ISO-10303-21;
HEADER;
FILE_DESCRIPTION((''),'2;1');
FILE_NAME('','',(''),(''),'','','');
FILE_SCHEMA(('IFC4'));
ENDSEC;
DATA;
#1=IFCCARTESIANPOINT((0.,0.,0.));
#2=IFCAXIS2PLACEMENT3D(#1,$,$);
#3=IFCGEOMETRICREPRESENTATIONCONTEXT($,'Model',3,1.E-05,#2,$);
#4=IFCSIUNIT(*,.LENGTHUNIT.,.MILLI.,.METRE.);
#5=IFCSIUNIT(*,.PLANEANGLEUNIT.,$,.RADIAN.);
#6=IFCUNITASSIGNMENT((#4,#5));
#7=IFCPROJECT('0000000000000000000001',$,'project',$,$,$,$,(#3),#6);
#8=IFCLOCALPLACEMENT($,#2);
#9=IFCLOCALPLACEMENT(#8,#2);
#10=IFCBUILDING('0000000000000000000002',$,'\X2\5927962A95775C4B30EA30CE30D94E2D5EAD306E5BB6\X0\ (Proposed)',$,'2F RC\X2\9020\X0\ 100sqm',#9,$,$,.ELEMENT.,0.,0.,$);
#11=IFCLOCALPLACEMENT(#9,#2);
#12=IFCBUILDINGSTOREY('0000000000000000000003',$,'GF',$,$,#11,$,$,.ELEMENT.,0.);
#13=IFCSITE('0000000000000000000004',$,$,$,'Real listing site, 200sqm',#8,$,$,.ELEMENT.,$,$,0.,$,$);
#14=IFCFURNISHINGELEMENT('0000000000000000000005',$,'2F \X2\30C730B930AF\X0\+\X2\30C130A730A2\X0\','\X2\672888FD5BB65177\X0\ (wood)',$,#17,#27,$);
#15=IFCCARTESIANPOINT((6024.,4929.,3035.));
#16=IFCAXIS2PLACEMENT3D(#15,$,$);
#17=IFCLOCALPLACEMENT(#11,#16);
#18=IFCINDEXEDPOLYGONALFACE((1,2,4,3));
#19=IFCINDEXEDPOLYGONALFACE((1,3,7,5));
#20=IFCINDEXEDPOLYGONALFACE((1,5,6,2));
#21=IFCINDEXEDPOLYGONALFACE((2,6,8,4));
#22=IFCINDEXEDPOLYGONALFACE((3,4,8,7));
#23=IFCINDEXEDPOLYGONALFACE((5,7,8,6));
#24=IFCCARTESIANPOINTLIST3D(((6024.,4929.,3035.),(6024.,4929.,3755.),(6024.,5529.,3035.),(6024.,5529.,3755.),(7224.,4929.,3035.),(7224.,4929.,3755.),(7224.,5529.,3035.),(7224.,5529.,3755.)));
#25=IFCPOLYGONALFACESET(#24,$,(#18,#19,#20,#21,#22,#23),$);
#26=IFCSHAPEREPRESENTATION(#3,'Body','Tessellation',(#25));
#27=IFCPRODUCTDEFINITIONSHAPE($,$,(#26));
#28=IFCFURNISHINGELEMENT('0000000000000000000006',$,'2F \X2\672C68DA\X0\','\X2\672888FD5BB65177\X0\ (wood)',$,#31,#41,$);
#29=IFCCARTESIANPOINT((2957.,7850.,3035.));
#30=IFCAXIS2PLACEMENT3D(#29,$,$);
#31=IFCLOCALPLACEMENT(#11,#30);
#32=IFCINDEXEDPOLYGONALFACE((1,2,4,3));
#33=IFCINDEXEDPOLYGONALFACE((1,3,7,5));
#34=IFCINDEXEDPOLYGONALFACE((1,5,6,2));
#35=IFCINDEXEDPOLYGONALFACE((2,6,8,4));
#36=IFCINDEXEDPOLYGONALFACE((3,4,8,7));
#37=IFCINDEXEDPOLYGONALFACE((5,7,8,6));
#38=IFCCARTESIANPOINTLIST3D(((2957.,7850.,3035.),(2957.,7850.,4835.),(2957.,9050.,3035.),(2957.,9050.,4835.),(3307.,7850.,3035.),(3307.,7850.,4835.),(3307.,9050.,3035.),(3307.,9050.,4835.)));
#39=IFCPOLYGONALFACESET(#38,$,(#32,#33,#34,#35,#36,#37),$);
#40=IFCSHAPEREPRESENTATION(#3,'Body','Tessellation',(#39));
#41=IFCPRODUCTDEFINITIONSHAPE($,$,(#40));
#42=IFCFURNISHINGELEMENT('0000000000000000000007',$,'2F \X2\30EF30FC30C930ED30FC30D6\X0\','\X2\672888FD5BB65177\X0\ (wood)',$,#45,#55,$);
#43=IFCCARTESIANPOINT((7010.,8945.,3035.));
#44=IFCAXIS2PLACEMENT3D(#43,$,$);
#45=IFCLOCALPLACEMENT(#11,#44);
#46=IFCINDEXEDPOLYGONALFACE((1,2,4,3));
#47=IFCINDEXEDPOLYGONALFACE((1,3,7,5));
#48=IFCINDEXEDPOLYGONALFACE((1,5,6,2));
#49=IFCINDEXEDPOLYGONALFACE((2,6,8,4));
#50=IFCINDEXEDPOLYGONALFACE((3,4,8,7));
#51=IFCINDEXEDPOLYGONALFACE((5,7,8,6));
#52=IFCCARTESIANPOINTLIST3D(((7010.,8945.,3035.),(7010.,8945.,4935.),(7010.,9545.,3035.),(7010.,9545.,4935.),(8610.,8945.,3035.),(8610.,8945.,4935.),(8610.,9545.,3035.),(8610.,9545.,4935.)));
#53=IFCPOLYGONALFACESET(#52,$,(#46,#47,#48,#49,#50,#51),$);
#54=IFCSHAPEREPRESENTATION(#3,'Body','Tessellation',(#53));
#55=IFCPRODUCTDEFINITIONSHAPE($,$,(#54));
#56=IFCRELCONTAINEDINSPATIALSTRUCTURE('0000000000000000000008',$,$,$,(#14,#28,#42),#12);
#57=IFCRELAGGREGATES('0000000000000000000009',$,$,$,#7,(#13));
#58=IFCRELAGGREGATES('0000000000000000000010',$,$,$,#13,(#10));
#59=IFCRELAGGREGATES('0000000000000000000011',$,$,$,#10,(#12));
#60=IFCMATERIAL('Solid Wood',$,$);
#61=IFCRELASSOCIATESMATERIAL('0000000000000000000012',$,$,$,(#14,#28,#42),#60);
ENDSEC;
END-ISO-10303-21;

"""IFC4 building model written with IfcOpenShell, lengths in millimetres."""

from ifc_helpers import new_model, si_unit, frame, frame_2d, origin, place, context, project, spatial, rectangle, extrude, material, element, save


model = new_model("IFC4")

# Units and contexts
model_context = context("Model", 3, precision=1e-05, world=origin())
ifc_project = project(units=[si_unit("LENGTHUNIT", "METRE", prefix="MILLI"), si_unit("PLANEANGLEUNIT", "RADIAN")], contexts=[model_context])

# Site, building, storey
site_placement = place(None, origin())
site = spatial("IfcSite", under=ifc_project, at=site_placement, ObjectType="Real listing site, 200sqm", CompositionType="ELEMENT", RefElevation=0.0)
building_placement = place(site_placement, origin())
building = spatial("IfcBuilding", under=site, at=building_placement, Name="大阪長屋リノベ中庭の家 (Proposed)", ObjectType="2F RC造 100sqm", CompositionType="ELEMENT", ElevationOfRefHeight=0.0, ElevationOfTerrain=0.0)
storey_placement = place(building_placement, origin())
storey = spatial("IfcBuildingStorey", under=building, at=storey_placement, Name="GF", CompositionType="ELEMENT", Elevation=0.0)

# Shared definitions
ifc_material_1 = material(Name="Solid Wood")

# Furnishing elements
furnishing_1_placement = place(storey_placement, frame((6024.0, 4929.0, 3035.0)))
element("IfcFurnishingElement", 1, at=furnishing_1_placement, inside=storey, material=ifc_material_1, Name="2F デスク+チェア", Description="木製家具 (wood)", context=model_context, shape_type="SweptSolid", body=[
    extrude(rectangle(XDim=1200.0, YDim=600.0, at=frame_2d((600.0, 300.0))), frame((6024.0, 4929.0, 3035.0)), (0.0, 0.0, 1.0), 720.0),
])
furnishing_2_placement = place(storey_placement, frame((2957.0, 7850.0, 3035.0)))
element("IfcFurnishingElement", 2, at=furnishing_2_placement, inside=storey, material=ifc_material_1, Name="2F 本棚", Description="木製家具 (wood)", context=model_context, shape_type="SweptSolid", body=[
    extrude(rectangle(XDim=350.0, YDim=1200.0, at=frame_2d((175.0, 600.0))), frame((2957.0, 7850.0, 3035.0)), (0.0, 0.0, 1.0), 1800.0),
])
furnishing_3_placement = place(storey_placement, frame((7010.0, 8945.0, 3035.0)))
element("IfcFurnishingElement", 3, at=furnishing_3_placement, inside=storey, material=ifc_material_1, Name="2F ワードローブ", Description="木製家具 (wood)", context=model_context, shape_type="SweptSolid", body=[
    extrude(rectangle(XDim=1600.0, YDim=600.0, at=frame_2d((800.0, 300.0))), frame((7010.0, 8945.0, 3035.0)), (0.0, 0.0, 1.0), 1900.0),
])

save(model, "model.ifc")
